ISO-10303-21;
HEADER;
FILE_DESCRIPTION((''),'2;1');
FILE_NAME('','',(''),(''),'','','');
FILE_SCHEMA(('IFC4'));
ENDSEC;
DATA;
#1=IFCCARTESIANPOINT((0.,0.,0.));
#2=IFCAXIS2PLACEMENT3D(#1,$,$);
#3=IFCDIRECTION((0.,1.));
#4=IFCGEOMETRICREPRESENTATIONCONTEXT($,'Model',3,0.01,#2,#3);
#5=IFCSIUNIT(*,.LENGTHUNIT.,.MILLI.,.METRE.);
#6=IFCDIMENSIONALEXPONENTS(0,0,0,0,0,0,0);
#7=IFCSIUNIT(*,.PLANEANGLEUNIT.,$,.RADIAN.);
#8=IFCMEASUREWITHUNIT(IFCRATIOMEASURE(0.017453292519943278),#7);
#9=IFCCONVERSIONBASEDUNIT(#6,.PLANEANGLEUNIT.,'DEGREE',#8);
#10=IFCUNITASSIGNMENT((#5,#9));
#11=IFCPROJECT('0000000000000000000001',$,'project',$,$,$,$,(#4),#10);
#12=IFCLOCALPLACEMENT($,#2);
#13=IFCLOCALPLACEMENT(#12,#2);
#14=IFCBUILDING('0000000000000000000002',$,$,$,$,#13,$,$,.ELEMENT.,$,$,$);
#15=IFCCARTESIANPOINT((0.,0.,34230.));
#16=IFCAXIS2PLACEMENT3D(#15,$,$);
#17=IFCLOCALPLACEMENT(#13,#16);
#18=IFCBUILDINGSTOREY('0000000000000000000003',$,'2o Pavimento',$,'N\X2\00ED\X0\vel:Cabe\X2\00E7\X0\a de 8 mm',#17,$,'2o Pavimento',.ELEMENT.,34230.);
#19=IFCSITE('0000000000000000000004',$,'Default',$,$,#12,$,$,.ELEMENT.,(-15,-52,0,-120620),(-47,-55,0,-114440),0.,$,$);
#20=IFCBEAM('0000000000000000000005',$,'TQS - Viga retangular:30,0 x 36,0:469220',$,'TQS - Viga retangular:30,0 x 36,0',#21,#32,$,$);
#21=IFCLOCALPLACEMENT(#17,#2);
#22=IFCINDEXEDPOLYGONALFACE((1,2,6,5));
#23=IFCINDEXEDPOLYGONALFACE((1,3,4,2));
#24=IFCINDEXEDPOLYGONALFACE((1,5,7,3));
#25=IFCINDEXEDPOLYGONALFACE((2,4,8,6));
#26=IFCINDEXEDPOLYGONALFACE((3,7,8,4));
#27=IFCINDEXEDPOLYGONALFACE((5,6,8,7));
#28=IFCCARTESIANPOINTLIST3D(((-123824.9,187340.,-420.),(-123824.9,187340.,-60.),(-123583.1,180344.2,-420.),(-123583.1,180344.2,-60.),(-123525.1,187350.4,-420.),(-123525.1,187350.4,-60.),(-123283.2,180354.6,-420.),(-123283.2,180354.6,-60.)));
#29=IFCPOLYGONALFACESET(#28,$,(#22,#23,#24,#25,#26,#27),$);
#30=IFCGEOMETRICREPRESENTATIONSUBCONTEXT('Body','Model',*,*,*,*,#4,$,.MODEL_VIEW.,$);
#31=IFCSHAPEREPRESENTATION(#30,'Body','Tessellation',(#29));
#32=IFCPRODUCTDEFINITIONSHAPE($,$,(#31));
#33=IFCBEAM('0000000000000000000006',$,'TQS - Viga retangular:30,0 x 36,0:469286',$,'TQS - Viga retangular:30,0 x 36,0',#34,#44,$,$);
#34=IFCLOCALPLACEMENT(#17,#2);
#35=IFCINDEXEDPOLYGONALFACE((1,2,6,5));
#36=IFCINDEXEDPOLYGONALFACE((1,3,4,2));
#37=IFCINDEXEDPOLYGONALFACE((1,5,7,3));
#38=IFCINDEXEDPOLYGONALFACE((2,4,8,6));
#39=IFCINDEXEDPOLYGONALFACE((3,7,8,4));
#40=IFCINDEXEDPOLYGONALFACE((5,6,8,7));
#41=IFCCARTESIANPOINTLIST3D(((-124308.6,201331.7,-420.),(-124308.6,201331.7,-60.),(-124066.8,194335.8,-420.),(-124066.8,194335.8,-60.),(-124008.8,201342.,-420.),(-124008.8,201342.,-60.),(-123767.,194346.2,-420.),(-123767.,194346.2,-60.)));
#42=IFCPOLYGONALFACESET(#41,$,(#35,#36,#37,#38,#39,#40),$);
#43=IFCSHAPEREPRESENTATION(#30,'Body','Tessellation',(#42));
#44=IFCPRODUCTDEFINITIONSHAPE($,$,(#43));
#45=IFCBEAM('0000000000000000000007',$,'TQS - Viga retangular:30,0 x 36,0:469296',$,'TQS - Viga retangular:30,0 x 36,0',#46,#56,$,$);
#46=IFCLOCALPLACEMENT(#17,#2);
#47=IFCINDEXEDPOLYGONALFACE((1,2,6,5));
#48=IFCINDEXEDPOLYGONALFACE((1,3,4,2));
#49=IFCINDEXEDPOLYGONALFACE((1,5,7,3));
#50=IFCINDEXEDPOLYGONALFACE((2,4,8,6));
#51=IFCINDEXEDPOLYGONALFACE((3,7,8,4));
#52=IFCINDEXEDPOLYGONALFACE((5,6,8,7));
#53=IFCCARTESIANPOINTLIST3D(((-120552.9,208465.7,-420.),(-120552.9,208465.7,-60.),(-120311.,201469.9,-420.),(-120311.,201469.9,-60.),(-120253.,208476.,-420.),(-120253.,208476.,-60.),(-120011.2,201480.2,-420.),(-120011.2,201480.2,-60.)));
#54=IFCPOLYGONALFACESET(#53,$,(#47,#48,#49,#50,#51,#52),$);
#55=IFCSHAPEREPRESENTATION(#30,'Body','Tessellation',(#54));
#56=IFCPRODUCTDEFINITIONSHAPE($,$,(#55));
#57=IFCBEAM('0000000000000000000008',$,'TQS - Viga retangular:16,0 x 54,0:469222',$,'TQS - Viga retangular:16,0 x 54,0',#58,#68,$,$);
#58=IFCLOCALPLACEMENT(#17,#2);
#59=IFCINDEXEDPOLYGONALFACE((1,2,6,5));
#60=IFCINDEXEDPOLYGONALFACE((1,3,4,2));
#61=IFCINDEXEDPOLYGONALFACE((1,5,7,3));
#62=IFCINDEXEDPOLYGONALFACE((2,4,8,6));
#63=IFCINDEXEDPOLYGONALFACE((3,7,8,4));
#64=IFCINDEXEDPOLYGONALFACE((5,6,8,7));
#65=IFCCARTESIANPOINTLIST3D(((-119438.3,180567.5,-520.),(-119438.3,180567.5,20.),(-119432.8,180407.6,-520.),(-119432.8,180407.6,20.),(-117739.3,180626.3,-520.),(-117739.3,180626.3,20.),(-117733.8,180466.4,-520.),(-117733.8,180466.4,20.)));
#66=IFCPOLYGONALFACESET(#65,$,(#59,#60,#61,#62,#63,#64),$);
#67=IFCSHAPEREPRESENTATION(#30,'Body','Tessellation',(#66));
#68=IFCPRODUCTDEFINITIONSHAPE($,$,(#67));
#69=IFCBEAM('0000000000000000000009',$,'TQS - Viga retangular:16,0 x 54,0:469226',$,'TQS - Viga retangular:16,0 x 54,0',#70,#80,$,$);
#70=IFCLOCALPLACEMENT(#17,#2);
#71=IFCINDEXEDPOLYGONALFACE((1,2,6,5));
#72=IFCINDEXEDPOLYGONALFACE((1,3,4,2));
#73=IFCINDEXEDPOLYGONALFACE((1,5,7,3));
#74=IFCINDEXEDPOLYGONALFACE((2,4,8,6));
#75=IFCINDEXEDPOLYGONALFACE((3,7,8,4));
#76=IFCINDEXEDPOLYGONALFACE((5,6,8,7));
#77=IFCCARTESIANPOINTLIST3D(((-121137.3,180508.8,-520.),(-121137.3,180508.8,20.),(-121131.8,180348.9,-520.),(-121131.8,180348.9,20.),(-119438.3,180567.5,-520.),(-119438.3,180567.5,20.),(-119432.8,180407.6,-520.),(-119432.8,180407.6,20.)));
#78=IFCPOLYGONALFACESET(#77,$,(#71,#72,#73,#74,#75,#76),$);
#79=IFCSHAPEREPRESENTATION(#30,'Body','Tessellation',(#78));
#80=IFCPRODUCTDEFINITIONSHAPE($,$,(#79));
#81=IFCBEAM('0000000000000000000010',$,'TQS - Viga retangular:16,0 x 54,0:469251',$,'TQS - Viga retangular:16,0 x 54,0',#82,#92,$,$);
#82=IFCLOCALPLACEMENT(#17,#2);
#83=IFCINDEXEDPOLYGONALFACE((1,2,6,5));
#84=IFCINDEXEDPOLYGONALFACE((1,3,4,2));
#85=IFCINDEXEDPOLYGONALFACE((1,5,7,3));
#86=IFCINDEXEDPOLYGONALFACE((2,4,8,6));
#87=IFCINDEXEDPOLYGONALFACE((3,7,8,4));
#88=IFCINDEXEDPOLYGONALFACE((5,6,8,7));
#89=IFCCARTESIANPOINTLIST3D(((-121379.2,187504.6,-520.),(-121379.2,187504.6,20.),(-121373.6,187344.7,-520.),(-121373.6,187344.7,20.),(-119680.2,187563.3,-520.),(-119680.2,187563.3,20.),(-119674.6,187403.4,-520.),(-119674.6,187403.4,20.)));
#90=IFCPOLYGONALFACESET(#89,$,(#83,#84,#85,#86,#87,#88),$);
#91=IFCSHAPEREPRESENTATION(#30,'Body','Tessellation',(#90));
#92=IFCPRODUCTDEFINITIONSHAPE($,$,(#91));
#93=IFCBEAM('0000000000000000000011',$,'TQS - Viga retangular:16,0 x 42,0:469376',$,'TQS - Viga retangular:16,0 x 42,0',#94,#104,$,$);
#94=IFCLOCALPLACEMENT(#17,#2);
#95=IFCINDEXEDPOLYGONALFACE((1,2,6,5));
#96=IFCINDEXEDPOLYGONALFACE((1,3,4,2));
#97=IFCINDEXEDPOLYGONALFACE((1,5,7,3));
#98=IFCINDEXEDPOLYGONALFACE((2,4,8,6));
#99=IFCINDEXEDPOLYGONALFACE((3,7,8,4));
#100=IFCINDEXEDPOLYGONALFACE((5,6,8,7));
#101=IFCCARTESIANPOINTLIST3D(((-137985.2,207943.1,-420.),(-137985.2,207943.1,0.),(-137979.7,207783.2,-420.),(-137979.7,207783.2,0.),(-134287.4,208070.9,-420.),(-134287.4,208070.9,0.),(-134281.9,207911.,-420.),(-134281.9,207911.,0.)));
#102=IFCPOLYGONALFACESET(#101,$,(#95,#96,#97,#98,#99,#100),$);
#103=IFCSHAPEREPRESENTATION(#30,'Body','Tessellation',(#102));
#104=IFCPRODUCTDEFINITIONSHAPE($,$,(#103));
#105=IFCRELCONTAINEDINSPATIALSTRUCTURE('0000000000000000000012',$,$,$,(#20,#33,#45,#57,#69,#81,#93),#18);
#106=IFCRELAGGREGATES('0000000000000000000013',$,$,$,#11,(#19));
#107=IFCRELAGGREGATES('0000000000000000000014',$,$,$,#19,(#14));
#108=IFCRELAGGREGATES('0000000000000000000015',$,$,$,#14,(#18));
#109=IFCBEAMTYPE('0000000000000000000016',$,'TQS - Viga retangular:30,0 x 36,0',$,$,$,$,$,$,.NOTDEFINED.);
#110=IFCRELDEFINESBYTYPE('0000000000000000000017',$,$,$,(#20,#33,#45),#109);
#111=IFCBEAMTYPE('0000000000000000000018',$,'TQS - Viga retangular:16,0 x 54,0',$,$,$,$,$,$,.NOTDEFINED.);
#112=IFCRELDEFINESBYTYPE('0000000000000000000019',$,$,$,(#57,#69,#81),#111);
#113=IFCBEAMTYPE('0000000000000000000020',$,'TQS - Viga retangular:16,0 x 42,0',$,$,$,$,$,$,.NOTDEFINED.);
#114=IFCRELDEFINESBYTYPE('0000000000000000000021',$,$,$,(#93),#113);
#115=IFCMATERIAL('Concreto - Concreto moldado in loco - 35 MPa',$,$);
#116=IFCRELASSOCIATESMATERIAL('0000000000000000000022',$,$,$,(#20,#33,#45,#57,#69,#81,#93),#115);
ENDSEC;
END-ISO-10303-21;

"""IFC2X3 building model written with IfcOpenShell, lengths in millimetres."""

from ifc_helpers import new_model, entity, si_unit, converted_unit, direction, frame, frame_2d, origin, place, context, subcontext, project, spatial, rectangle, extrude, material, type_object, element, save


model = new_model("IFC2X3")

# Units and contexts
model_context = context("Model", 3, precision=0.01, world=origin(), true_north=direction((0.0, 1.0)))
body_context = subcontext(model_context, "Body", "Model", "MODEL_VIEW")
ifc_project = project(units=[si_unit("LENGTHUNIT", "METRE", prefix="MILLI"), converted_unit("PLANEANGLEUNIT", "DEGREE", entity("IfcRatioMeasure", 0.017453292519943278), si_unit("PLANEANGLEUNIT", "RADIAN"), dimensions=[0, 0, 0, 0, 0, 0, 0])], contexts=[model_context])

# Site, building, storey
site_placement = place(None, origin())
site = spatial("IfcSite", under=ifc_project, at=site_placement, Name="Default", CompositionType="ELEMENT", RefLatitude=(-15, -52, 0, -120620), RefLongitude=(-47, -55, 0, -114440), RefElevation=0.0)
building_placement = place(site_placement, origin())
building = spatial("IfcBuilding", under=site, at=building_placement, CompositionType="ELEMENT")
storey_placement = place(building_placement, frame((0.0, 0.0, 34230.0)))
storey = spatial("IfcBuildingStorey", under=building, at=storey_placement, Name="2o Pavimento", ObjectType="Nível:Cabeça de 8 mm", LongName="2o Pavimento", CompositionType="ELEMENT", Elevation=34230.0)

# Beams
ifc_material = material(Name="Concreto - Concreto moldado in loco - 35 MPa")
beam_type_1 = type_object("IfcBeamType", Name="TQS - Viga retangular:30,0 x 36,0", PredefinedType="NOTDEFINED")
beam_1_placement = place(storey_placement, frame((-123433.2, 180349.4, -60.0), z_axis=(0.0, 0.0, 1.0), x_axis=(-0.034551, 0.999403, 0.0)))
element("IfcBeam", 1, at=beam_1_placement, inside=storey, type_object=beam_type_1, material=ifc_material, Name="TQS - Viga retangular:30,0 x 36,0:469220", ObjectType="TQS - Viga retangular:30,0 x 36,0", context=body_context, shape_type="SweptSolid", body=[
    extrude(rectangle(XDim=360.0, YDim=300.0, at=frame_2d((0.0, 0.0), x_axis=(1.0, 0.0))), frame((0.0, 0.0, -180.0), z_axis=(1.0, 0.0, 0.0), x_axis=(0.0, 0.0, -1.0)), (0.0, 0.0, 1.0), 7000.0),
])
beam_2_placement = place(storey_placement, frame((-123916.9, 194341.0, -60.0), z_axis=(0.0, 0.0, 1.0), x_axis=(-0.034551, 0.999403, 0.0)))
element("IfcBeam", 2, at=beam_2_placement, inside=storey, type_object=beam_type_1, material=ifc_material, Name="TQS - Viga retangular:30,0 x 36,0:469286", ObjectType="TQS - Viga retangular:30,0 x 36,0", context=body_context, shape_type="SweptSolid", body=[
    extrude(rectangle(XDim=360.0, YDim=300.0, at=frame_2d((0.0, 0.0), x_axis=(1.0, 0.0))), frame((0.0, 0.0, -180.0), z_axis=(1.0, 0.0, 0.0), x_axis=(0.0, 0.0, -1.0)), (0.0, 0.0, 1.0), 7000.0),
])
beam_3_placement = place(storey_placement, frame((-120161.1, 201475.0, -60.0), z_axis=(0.0, 0.0, 1.0), x_axis=(-0.034551, 0.999403, 0.0)))
element("IfcBeam", 3, at=beam_3_placement, inside=storey, type_object=beam_type_1, material=ifc_material, Name="TQS - Viga retangular:30,0 x 36,0:469296", ObjectType="TQS - Viga retangular:30,0 x 36,0", context=body_context, shape_type="SweptSolid", body=[
    extrude(rectangle(XDim=360.0, YDim=300.0, at=frame_2d((0.0, 0.0), x_axis=(1.0, 0.0))), frame((0.0, 0.0, -180.0), z_axis=(1.0, 0.0, 0.0), x_axis=(0.0, 0.0, -1.0)), (0.0, 0.0, 1.0), 7000.0),
])
beam_type_2 = type_object("IfcBeamType", Name="TQS - Viga retangular:16,0 x 54,0", PredefinedType="NOTDEFINED")
beam_4_placement = place(storey_placement, frame((-117736.6, 180546.3, 20.0), z_axis=(0.0, 0.0, 1.0), x_axis=(-0.999403, -0.034551, 0.0)))
element("IfcBeam", 4, at=beam_4_placement, inside=storey, type_object=beam_type_2, material=ifc_material, Name="TQS - Viga retangular:16,0 x 54,0:469222", ObjectType="TQS - Viga retangular:16,0 x 54,0", context=body_context, shape_type="SweptSolid", body=[
    extrude(rectangle(XDim=540.0, YDim=160.0, at=frame_2d((0.0, 0.0), x_axis=(1.0, 0.0))), frame((0.0, 0.0, -270.0), z_axis=(1.0, 0.0, 0.0), x_axis=(0.0, 0.0, -1.0)), (0.0, 0.0, 1.0), 1700.0),
])
beam_5_placement = place(storey_placement, frame((-119435.5, 180487.6, 20.0), z_axis=(0.0, 0.0, 1.0), x_axis=(-0.999403, -0.034551, 0.0)))
element("IfcBeam", 5, at=beam_5_placement, inside=storey, type_object=beam_type_2, material=ifc_material, Name="TQS - Viga retangular:16,0 x 54,0:469226", ObjectType="TQS - Viga retangular:16,0 x 54,0", context=body_context, shape_type="SweptSolid", body=[
    extrude(rectangle(XDim=540.0, YDim=160.0, at=frame_2d((0.0, 0.0), x_axis=(1.0, 0.0))), frame((0.0, 0.0, -270.0), z_axis=(1.0, 0.0, 0.0), x_axis=(0.0, 0.0, -1.0)), (0.0, 0.0, 1.0), 1700.0),
])
beam_6_placement = place(storey_placement, frame((-119677.4, 187483.4, 20.0), z_axis=(0.0, 0.0, 1.0), x_axis=(-0.999403, -0.034551, 0.0)))
element("IfcBeam", 6, at=beam_6_placement, inside=storey, type_object=beam_type_2, material=ifc_material, Name="TQS - Viga retangular:16,0 x 54,0:469251", ObjectType="TQS - Viga retangular:16,0 x 54,0", context=body_context, shape_type="SweptSolid", body=[
    extrude(rectangle(XDim=540.0, YDim=160.0, at=frame_2d((0.0, 0.0), x_axis=(1.0, 0.0))), frame((0.0, 0.0, -270.0), z_axis=(1.0, 0.0, 0.0), x_axis=(0.0, 0.0, -1.0)), (0.0, 0.0, 1.0), 1700.0),
])
beam_type_3 = type_object("IfcBeamType", Name="TQS - Viga retangular:16,0 x 42,0", PredefinedType="NOTDEFINED")
beam_7_placement = place(storey_placement, frame((-134204.7, 207993.7, 0.0), z_axis=(0.0, 0.0, 1.0), x_axis=(-0.999403, -0.034551, 0.0)))
element("IfcBeam", 7, at=beam_7_placement, inside=storey, type_object=beam_type_3, material=ifc_material, Name="TQS - Viga retangular:16,0 x 42,0:469376", ObjectType="TQS - Viga retangular:16,0 x 42,0", context=body_context, shape_type="SweptSolid", body=[
    extrude(rectangle(XDim=420.0, YDim=160.0, at=frame_2d((0.0, 0.0), x_axis=(1.0, 0.0))), frame((80.0, 0.0, -210.0), z_axis=(1.0, 0.0, 0.0), x_axis=(0.0, 0.0, -1.0)), (0.0, 0.0, 1.0), 3700.0),
])

save(model, "model.ifc")
